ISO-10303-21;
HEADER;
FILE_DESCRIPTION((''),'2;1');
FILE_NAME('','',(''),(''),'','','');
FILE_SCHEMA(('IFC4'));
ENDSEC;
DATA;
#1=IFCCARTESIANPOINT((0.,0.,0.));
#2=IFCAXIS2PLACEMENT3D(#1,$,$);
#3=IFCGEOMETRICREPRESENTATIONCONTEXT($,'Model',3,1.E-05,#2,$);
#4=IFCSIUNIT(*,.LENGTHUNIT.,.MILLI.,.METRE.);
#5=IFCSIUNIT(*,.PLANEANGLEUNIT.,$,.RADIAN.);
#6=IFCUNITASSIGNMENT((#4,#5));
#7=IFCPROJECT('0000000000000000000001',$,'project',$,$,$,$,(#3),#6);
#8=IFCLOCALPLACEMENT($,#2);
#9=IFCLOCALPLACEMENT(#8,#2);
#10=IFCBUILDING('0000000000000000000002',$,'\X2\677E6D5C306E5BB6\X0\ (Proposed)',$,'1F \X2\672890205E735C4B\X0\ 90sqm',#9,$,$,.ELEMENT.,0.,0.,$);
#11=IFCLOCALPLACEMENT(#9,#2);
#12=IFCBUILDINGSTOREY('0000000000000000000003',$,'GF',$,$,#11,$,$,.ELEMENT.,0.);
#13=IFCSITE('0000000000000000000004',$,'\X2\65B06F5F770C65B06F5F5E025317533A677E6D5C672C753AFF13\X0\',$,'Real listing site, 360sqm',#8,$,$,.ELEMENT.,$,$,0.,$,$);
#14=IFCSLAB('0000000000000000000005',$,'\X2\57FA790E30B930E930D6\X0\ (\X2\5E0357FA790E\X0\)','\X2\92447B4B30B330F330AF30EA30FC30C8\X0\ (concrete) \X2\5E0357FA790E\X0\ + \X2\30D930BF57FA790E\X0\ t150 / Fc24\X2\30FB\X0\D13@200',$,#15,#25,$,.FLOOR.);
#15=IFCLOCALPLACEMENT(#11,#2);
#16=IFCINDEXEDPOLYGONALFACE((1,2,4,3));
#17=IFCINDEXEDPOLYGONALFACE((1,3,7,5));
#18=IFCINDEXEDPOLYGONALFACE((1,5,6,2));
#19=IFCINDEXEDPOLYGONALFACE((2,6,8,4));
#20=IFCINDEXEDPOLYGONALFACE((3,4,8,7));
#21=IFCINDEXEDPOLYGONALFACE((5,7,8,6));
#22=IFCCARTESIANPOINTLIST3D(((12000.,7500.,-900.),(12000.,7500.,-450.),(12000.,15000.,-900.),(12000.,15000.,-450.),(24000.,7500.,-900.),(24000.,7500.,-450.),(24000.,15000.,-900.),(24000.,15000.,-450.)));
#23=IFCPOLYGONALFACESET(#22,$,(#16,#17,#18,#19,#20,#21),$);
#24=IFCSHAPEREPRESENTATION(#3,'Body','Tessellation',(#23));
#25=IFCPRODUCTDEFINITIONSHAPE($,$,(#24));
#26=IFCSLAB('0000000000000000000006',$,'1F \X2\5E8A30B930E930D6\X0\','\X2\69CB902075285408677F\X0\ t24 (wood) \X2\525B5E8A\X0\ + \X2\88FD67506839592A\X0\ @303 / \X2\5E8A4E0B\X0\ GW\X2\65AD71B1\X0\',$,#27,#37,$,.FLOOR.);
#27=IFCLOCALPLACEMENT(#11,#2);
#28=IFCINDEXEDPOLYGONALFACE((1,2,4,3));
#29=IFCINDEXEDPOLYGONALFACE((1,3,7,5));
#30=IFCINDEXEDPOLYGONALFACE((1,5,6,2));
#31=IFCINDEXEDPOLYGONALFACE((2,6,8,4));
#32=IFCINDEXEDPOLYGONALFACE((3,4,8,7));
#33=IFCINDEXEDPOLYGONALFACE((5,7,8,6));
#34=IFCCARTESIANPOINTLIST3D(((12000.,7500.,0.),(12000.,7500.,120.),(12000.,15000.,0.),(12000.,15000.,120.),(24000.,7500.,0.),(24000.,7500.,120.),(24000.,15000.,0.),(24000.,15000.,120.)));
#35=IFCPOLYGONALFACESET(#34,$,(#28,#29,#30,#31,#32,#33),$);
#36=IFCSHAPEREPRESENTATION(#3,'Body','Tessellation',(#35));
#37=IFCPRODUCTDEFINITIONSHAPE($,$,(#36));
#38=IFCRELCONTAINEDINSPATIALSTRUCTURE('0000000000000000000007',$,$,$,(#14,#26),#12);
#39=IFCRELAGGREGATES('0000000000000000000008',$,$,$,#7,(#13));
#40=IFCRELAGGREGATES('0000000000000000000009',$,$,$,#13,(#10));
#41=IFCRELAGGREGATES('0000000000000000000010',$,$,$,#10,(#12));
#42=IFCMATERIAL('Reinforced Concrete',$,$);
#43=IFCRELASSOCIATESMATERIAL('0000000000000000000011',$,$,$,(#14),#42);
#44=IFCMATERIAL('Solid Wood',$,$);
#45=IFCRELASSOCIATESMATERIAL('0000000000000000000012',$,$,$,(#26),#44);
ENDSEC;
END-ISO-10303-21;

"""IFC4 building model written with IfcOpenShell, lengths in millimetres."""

from ifc_helpers import new_model, si_unit, frame, frame_2d, origin, place, context, project, spatial, rectangle, extrude, material, element, save


model = new_model("IFC4")

# Units and contexts
model_context = context("Model", 3, precision=1e-05, world=origin())
ifc_project = project(units=[si_unit("LENGTHUNIT", "METRE", prefix="MILLI"), si_unit("PLANEANGLEUNIT", "RADIAN")], contexts=[model_context])

# Site, building, storey
site_placement = place(None, origin())
site = spatial("IfcSite", under=ifc_project, at=site_placement, Name="新潟県新潟市北区松浜本町３", ObjectType="Real listing site, 360sqm", CompositionType="ELEMENT", RefElevation=0.0)
building_placement = place(site_placement, origin())
building = spatial("IfcBuilding", under=site, at=building_placement, Name="松浜の家 (Proposed)", ObjectType="1F 木造平屋 90sqm", CompositionType="ELEMENT", ElevationOfRefHeight=0.0, ElevationOfTerrain=0.0)
storey_placement = place(building_placement, origin())
storey = spatial("IfcBuildingStorey", under=building, at=storey_placement, Name="GF", CompositionType="ELEMENT", Elevation=0.0)

# Slabs
ifc_material_1 = material(Name="Reinforced Concrete")
slab_1_placement = place(storey_placement, frame((6000.0, 3750.0, -450.0)))
element("IfcSlab", 1, at=slab_1_placement, inside=storey, material=ifc_material_1, Name="基礎スラブ (布基礎)", Description="鉄筋コンクリート (concrete) 布基礎 + ベタ基礎 t150 / Fc24・D13@200", PredefinedType="FLOOR", context=model_context, shape_type="SweptSolid", body=[
    extrude(rectangle(XDim=12000.0, YDim=7500.0, at=frame_2d((6000.0, 3750.0))), frame((6000.0, 3750.0, -450.0)), (0.0, 0.0, 1.0), 450.0),
])
ifc_material_2 = material(Name="Solid Wood")
slab_2_placement = place(storey_placement, frame((6000.0, 3750.0, 0.0)))
element("IfcSlab", 2, at=slab_2_placement, inside=storey, material=ifc_material_2, Name="1F 床スラブ", Description="構造用合板 t24 (wood) 剛床 + 製材根太 @303 / 床下 GW断熱", PredefinedType="FLOOR", context=model_context, shape_type="SweptSolid", body=[
    extrude(rectangle(XDim=12000.0, YDim=7500.0, at=frame_2d((6000.0, 3750.0))), frame((6000.0, 3750.0, 0.0)), (0.0, 0.0, 1.0), 120.0),
])

save(model, "model.ifc")
